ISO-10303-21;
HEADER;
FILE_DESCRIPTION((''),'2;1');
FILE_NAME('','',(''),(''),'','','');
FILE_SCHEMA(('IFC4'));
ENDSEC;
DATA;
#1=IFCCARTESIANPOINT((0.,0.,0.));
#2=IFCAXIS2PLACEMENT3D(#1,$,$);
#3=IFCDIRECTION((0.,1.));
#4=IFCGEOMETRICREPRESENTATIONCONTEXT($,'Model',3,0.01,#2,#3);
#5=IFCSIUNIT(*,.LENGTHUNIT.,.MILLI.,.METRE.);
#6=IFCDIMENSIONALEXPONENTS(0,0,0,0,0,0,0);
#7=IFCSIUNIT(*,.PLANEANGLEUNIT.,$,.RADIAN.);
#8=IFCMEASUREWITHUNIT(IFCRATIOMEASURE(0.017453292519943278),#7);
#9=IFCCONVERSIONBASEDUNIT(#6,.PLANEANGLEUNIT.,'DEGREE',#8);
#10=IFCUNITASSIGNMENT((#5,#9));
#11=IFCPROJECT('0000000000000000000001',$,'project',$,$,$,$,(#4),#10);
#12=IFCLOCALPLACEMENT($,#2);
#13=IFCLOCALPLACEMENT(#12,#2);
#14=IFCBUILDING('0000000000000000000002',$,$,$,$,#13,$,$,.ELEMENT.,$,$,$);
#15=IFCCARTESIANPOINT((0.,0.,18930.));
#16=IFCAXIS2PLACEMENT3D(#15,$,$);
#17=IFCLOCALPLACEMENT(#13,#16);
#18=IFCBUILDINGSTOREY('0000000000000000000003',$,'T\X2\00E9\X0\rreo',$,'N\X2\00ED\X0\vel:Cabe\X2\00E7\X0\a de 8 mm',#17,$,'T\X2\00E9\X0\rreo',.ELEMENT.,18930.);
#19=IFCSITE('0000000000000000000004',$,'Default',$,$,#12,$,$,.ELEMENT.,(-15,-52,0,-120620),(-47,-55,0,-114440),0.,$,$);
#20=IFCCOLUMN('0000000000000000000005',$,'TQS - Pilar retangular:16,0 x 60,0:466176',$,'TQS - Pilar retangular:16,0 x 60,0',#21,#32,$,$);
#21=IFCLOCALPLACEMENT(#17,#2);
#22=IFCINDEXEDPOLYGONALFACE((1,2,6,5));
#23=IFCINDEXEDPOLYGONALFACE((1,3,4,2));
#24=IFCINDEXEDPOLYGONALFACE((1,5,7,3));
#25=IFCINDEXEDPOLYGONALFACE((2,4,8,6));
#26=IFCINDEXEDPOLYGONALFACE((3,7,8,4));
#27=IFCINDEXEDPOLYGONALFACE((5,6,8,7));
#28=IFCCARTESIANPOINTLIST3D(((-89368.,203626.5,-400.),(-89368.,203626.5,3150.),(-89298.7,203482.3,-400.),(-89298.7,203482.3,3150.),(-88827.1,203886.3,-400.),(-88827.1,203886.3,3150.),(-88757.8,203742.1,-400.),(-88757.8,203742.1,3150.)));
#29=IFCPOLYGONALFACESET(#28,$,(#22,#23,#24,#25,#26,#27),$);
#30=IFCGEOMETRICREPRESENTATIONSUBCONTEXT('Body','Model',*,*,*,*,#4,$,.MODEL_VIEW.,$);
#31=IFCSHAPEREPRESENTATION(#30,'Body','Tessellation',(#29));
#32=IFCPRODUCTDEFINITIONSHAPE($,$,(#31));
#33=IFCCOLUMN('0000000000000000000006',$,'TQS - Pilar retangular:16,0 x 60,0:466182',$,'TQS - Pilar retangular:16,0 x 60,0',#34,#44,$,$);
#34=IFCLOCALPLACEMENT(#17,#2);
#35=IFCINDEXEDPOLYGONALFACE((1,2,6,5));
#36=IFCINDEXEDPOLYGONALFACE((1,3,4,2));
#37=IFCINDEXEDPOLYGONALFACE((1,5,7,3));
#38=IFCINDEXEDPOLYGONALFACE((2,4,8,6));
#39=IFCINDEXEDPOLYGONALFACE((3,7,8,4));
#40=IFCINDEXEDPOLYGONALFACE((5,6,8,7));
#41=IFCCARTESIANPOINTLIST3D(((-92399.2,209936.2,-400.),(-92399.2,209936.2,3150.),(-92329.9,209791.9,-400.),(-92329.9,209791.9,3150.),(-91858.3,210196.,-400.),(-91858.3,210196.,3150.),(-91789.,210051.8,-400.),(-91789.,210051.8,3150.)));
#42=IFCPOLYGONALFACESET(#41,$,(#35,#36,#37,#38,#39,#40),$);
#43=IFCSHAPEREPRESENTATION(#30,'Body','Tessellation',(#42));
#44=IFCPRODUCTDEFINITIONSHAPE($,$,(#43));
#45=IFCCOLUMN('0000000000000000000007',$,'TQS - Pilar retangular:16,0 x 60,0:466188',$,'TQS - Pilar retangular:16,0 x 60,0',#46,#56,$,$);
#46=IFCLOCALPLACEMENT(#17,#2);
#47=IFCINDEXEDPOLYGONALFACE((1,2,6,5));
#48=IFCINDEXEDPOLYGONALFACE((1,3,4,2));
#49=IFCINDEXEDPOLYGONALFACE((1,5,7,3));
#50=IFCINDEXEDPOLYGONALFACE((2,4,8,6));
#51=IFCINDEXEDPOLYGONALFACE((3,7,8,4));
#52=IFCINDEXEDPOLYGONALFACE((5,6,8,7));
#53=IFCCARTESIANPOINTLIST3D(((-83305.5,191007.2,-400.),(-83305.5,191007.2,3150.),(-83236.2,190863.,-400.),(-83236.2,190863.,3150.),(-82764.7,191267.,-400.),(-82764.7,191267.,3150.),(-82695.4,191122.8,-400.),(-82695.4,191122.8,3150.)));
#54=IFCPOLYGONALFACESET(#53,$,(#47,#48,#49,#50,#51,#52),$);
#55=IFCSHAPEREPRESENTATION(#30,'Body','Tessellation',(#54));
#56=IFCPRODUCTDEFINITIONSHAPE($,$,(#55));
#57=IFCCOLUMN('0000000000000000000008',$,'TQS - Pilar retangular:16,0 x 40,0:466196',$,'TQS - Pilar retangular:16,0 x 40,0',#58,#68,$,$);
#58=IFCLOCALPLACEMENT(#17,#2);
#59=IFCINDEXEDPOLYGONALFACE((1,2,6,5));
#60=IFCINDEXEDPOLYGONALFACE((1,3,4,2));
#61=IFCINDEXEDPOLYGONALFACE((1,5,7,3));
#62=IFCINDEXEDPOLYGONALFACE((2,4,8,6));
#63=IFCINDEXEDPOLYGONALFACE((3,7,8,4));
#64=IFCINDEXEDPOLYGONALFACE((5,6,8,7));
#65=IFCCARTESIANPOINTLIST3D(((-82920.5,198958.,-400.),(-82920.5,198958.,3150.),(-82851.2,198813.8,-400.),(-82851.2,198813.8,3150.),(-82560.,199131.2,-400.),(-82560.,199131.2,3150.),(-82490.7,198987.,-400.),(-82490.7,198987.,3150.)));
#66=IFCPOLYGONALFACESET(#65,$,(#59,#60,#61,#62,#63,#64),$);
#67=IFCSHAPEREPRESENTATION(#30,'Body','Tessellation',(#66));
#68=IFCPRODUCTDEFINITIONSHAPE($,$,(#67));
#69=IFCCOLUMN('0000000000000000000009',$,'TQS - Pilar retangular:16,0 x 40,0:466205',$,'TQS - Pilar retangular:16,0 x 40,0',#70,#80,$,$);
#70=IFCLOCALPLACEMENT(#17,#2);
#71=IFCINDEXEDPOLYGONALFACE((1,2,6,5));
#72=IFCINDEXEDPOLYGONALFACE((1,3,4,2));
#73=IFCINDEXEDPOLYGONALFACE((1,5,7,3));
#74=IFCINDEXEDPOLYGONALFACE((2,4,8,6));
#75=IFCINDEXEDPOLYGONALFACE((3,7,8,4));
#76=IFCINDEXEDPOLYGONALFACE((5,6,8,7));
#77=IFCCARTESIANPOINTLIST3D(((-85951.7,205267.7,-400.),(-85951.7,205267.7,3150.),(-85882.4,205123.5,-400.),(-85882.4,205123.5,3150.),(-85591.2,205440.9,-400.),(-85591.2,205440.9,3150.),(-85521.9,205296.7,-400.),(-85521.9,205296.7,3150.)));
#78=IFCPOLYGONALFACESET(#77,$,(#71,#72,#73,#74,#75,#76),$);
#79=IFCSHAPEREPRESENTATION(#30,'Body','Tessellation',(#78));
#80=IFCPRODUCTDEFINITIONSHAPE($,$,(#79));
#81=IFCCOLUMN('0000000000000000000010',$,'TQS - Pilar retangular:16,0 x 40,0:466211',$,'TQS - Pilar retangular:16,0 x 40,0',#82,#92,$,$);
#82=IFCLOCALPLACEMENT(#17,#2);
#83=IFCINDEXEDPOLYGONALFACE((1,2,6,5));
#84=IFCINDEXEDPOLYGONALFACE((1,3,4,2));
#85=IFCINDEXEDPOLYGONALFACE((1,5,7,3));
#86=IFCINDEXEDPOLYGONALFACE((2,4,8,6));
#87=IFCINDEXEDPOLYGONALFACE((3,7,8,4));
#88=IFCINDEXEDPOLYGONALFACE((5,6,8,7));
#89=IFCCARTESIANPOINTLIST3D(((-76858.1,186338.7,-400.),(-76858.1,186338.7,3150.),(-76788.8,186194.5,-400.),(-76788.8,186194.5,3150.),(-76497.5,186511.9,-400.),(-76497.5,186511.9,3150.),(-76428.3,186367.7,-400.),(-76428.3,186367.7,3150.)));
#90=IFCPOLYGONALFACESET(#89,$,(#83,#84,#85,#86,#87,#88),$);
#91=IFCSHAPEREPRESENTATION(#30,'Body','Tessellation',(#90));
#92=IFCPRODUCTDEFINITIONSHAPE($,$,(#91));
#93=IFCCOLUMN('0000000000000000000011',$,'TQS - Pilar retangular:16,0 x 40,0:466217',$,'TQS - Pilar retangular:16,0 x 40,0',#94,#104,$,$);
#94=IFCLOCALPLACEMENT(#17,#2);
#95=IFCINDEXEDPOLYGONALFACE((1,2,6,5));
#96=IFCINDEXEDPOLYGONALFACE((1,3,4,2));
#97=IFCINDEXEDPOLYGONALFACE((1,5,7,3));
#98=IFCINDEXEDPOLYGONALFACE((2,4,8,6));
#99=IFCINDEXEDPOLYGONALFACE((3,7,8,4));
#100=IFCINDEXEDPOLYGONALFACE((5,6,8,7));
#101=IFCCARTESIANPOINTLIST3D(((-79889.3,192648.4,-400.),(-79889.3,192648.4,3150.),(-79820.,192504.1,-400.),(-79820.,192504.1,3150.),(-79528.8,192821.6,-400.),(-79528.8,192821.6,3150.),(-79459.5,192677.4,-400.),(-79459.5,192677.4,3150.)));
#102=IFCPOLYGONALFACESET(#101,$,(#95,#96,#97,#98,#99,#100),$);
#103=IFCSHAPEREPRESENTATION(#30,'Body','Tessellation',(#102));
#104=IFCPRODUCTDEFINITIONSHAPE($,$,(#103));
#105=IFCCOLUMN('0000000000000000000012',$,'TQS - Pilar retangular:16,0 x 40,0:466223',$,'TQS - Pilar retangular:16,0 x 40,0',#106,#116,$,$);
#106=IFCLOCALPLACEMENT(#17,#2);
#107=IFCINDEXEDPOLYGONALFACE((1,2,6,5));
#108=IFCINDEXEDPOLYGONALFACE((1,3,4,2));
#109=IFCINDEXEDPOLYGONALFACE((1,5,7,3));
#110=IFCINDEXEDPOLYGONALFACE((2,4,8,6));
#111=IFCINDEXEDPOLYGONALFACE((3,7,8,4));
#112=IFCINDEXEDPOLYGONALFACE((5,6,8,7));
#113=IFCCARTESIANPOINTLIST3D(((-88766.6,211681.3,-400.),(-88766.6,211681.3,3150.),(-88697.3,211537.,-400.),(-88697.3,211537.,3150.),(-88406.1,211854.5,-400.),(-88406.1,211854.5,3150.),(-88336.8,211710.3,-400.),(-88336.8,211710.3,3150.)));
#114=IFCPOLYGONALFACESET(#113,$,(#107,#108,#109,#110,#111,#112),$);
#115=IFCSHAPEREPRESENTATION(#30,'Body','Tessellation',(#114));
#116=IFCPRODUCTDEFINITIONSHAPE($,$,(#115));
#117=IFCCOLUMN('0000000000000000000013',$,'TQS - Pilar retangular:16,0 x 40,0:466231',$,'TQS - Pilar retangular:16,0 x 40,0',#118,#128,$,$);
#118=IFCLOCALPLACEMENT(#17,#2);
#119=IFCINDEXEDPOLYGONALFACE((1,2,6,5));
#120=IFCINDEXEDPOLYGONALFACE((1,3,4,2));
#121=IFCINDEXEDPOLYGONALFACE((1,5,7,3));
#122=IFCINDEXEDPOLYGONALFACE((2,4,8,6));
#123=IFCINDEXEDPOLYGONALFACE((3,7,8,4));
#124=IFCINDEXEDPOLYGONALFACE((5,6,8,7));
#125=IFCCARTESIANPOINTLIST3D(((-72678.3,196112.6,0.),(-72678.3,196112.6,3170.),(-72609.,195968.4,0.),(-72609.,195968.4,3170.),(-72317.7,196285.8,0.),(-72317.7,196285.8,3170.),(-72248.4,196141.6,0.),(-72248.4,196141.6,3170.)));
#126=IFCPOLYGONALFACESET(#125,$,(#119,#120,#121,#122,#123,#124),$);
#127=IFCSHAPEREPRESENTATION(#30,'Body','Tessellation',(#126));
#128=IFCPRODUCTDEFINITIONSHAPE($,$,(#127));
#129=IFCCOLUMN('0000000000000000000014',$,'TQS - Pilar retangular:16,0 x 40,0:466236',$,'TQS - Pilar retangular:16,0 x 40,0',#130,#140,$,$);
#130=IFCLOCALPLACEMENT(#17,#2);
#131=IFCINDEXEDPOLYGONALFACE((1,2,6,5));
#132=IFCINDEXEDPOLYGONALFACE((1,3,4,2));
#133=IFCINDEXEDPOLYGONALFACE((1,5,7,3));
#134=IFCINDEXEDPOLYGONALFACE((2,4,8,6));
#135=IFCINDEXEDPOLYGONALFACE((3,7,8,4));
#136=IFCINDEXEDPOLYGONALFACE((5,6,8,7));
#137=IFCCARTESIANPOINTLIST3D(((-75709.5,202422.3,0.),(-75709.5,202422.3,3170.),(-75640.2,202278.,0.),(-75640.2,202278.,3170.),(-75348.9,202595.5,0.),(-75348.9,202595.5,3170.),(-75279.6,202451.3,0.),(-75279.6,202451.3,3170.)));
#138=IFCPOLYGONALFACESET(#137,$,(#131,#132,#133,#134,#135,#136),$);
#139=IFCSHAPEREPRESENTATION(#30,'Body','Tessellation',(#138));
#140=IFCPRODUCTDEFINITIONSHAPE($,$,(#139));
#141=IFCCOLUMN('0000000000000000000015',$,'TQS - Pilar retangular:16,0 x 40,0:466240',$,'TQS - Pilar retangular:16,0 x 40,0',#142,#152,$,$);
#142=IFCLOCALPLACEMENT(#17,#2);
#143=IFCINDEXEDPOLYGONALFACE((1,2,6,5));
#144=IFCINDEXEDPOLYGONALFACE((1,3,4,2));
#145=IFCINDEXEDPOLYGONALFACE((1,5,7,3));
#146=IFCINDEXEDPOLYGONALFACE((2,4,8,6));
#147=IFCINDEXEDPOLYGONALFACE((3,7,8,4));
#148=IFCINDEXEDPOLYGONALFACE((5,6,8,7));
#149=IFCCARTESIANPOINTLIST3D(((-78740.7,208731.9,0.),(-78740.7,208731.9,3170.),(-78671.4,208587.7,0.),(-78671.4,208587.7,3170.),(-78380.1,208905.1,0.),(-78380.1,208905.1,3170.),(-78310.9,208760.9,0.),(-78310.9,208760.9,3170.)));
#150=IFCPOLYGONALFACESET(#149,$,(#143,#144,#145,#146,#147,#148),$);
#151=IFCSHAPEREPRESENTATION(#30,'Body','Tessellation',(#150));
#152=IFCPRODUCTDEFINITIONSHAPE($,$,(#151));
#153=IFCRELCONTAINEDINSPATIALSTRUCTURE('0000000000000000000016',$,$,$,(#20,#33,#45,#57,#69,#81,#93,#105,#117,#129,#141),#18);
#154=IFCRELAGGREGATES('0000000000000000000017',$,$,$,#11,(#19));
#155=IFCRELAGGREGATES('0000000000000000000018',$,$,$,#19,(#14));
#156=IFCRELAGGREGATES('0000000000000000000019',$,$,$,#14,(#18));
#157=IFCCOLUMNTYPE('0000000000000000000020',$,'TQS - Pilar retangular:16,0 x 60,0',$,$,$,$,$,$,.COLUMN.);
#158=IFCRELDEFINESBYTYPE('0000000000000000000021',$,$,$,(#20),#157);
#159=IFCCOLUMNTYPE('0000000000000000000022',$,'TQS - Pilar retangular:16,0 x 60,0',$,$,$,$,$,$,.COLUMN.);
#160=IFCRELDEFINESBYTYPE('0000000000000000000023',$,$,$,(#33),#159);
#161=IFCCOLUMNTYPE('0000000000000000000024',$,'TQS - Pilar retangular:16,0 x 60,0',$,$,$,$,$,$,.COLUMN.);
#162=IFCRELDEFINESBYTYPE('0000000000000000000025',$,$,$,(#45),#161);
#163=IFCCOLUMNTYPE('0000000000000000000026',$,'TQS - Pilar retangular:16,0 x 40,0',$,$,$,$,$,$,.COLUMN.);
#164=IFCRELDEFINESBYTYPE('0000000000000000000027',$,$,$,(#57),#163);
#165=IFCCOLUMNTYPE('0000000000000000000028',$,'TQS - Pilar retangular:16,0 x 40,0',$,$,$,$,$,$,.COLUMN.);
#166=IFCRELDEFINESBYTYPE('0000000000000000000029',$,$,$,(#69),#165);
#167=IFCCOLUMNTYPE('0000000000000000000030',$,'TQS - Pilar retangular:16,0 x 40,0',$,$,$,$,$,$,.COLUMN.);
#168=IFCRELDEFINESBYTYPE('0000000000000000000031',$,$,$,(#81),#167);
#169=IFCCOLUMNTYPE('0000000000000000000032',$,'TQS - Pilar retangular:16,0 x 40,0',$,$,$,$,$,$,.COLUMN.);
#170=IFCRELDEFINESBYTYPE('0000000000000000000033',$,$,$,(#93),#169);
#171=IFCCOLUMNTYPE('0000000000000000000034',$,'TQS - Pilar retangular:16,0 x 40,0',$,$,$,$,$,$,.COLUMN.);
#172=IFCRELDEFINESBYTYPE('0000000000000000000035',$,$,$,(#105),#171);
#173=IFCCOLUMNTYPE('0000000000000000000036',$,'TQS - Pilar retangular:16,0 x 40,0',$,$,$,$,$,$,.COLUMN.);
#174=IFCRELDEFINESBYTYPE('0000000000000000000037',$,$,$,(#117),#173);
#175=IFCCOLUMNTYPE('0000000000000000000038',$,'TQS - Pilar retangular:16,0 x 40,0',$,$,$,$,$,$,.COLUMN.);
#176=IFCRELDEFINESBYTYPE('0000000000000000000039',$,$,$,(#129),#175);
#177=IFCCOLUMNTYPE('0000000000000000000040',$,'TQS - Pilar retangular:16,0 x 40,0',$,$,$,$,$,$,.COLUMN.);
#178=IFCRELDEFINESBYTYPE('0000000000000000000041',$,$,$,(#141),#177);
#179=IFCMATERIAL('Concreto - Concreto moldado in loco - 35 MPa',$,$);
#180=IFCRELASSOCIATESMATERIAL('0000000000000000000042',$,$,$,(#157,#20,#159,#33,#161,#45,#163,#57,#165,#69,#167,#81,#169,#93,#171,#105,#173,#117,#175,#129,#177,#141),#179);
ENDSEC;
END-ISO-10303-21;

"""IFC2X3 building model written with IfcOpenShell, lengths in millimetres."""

from ifc_helpers import new_model, entity, si_unit, converted_unit, direction, frame, origin, origin_2d_with_axis, place, context, subcontext, project, spatial, rectangle, extrude, source, transform, mapped, material, type_object, type_shapes, element, save


model = new_model("IFC2X3")

# Units and contexts
model_context = context("Model", 3, precision=0.01, world=origin(), true_north=direction((0.0, 1.0)))
body_context = subcontext(model_context, "Body", "Model", "MODEL_VIEW")
ifc_project = project(units=[si_unit("LENGTHUNIT", "METRE", prefix="MILLI"), converted_unit("PLANEANGLEUNIT", "DEGREE", entity("IfcRatioMeasure", 0.017453292519943278), si_unit("PLANEANGLEUNIT", "RADIAN"), dimensions=[0, 0, 0, 0, 0, 0, 0])], contexts=[model_context])

# Site, building, storey
site_placement = place(None, origin())
site = spatial("IfcSite", under=ifc_project, at=site_placement, Name="Default", CompositionType="ELEMENT", RefLatitude=(-15, -52, 0, -120620), RefLongitude=(-47, -55, 0, -114440), RefElevation=0.0)
building_placement = place(site_placement, origin())
building = spatial("IfcBuilding", under=site, at=building_placement, CompositionType="ELEMENT")
storey_placement = place(building_placement, frame((0.0, 0.0, 18930.0)))
storey = spatial("IfcBuildingStorey", under=building, at=storey_placement, Name="Térreo", ObjectType="Nível:Cabeça de 8 mm", LongName="Térreo", CompositionType="ELEMENT", Elevation=18930.0)

# Columns
ifc_material = material(Name="Concreto - Concreto moldado in loco - 35 MPa")
column_type_1 = type_object("IfcColumnType", Name="TQS - Pilar retangular:16,0 x 60,0", PredefinedType="COLUMN", material=ifc_material)
shared_shape_1 = source(origin(), body_context, "Body", "SweptSolid", [
    extrude(rectangle(XDim=600.0, YDim=160.0, at=origin_2d_with_axis()), frame((-89062.9, 203684.3, 18530.0), z_axis=(0.0, 0.0, 1.0), x_axis=(-0.90138, -0.43303, 0.0)), (0.0, 0.0, 1.0), 3550.0),
])
type_shapes(column_type_1, [shared_shape_1])
column_1_placement = place(storey_placement, frame((0.0, 0.0, -18930.0)))
element("IfcColumn", 1, at=column_1_placement, inside=storey, type_object=column_type_1, material=ifc_material, Name="TQS - Pilar retangular:16,0 x 60,0:466176", ObjectType="TQS - Pilar retangular:16,0 x 60,0", context=body_context, shape_type="MappedRepresentation", body=[
    mapped(shared_shape_1, transform((0.0, 0.0, 0.0), scale=1.0)),
])
column_type_2 = type_object("IfcColumnType", Name="TQS - Pilar retangular:16,0 x 60,0", PredefinedType="COLUMN", material=ifc_material)
shared_shape_2 = source(origin(), body_context, "Body", "SweptSolid", [
    extrude(rectangle(XDim=600.0, YDim=160.0, at=origin_2d_with_axis()), frame((-92094.1, 209994.0, 18530.0), z_axis=(0.0, 0.0, 1.0), x_axis=(-0.90138, -0.43303, 0.0)), (0.0, 0.0, 1.0), 3550.0),
])
type_shapes(column_type_2, [shared_shape_2])
column_2_placement = place(storey_placement, frame((0.0, 0.0, -18930.0)))
element("IfcColumn", 2, at=column_2_placement, inside=storey, type_object=column_type_2, material=ifc_material, Name="TQS - Pilar retangular:16,0 x 60,0:466182", ObjectType="TQS - Pilar retangular:16,0 x 60,0", context=body_context, shape_type="MappedRepresentation", body=[
    mapped(shared_shape_2, transform((0.0, 0.0, 0.0), scale=1.0)),
])
column_type_3 = type_object("IfcColumnType", Name="TQS - Pilar retangular:16,0 x 60,0", PredefinedType="COLUMN", material=ifc_material)
shared_shape_3 = source(origin(), body_context, "Body", "SweptSolid", [
    extrude(rectangle(XDim=600.0, YDim=160.0, at=origin_2d_with_axis()), frame((-83000.5, 191065.0, 18530.0), z_axis=(0.0, 0.0, 1.0), x_axis=(-0.90138, -0.43303, 0.0)), (0.0, 0.0, 1.0), 3550.0),
])
type_shapes(column_type_3, [shared_shape_3])
column_3_placement = place(storey_placement, frame((0.0, 0.0, -18930.0)))
element("IfcColumn", 3, at=column_3_placement, inside=storey, type_object=column_type_3, material=ifc_material, Name="TQS - Pilar retangular:16,0 x 60,0:466188", ObjectType="TQS - Pilar retangular:16,0 x 60,0", context=body_context, shape_type="MappedRepresentation", body=[
    mapped(shared_shape_3, transform((0.0, 0.0, 0.0), scale=1.0)),
])
column_type_4 = type_object("IfcColumnType", Name="TQS - Pilar retangular:16,0 x 40,0", PredefinedType="COLUMN", material=ifc_material)
shared_shape_4 = source(origin(), body_context, "Body", "SweptSolid", [
    extrude(rectangle(XDim=400.0, YDim=160.0, at=origin_2d_with_axis()), frame((-82705.6, 198972.5, 18530.0), z_axis=(0.0, 0.0, 1.0), x_axis=(-0.90138, -0.43303, 0.0)), (0.0, 0.0, 1.0), 3550.0),
])
type_shapes(column_type_4, [shared_shape_4])
column_4_placement = place(storey_placement, frame((0.0, 0.0, -18930.0)))
element("IfcColumn", 4, at=column_4_placement, inside=storey, type_object=column_type_4, material=ifc_material, Name="TQS - Pilar retangular:16,0 x 40,0:466196", ObjectType="TQS - Pilar retangular:16,0 x 40,0", context=body_context, shape_type="MappedRepresentation", body=[
    mapped(shared_shape_4, transform((0.0, 0.0, 0.0), scale=1.0)),
])
column_type_5 = type_object("IfcColumnType", Name="TQS - Pilar retangular:16,0 x 40,0", PredefinedType="COLUMN", material=ifc_material)
shared_shape_5 = source(origin(), body_context, "Body", "SweptSolid", [
    extrude(rectangle(XDim=400.0, YDim=160.0, at=origin_2d_with_axis()), frame((-85736.8, 205282.2, 18530.0), z_axis=(0.0, 0.0, 1.0), x_axis=(-0.90138, -0.43303, 0.0)), (0.0, 0.0, 1.0), 3550.0),
])
type_shapes(column_type_5, [shared_shape_5])
column_5_placement = place(storey_placement, frame((0.0, 0.0, -18930.0)))
element("IfcColumn", 5, at=column_5_placement, inside=storey, type_object=column_type_5, material=ifc_material, Name="TQS - Pilar retangular:16,0 x 40,0:466205", ObjectType="TQS - Pilar retangular:16,0 x 40,0", context=body_context, shape_type="MappedRepresentation", body=[
    mapped(shared_shape_5, transform((0.0, 0.0, 0.0), scale=1.0)),
])
column_type_6 = type_object("IfcColumnType", Name="TQS - Pilar retangular:16,0 x 40,0", PredefinedType="COLUMN", material=ifc_material)
shared_shape_6 = source(origin(), body_context, "Body", "SweptSolid", [
    extrude(rectangle(XDim=400.0, YDim=160.0, at=origin_2d_with_axis()), frame((-76643.2, 186353.2, 18530.0), z_axis=(0.0, 0.0, 1.0), x_axis=(-0.90138, -0.43303, 0.0)), (0.0, 0.0, 1.0), 3550.0),
])
type_shapes(column_type_6, [shared_shape_6])
column_6_placement = place(storey_placement, frame((0.0, 0.0, -18930.0)))
element("IfcColumn", 6, at=column_6_placement, inside=storey, type_object=column_type_6, material=ifc_material, Name="TQS - Pilar retangular:16,0 x 40,0:466211", ObjectType="TQS - Pilar retangular:16,0 x 40,0", context=body_context, shape_type="MappedRepresentation", body=[
    mapped(shared_shape_6, transform((0.0, 0.0, 0.0), scale=1.0)),
])
column_type_7 = type_object("IfcColumnType", Name="TQS - Pilar retangular:16,0 x 40,0", PredefinedType="COLUMN", material=ifc_material)
shared_shape_7 = source(origin(), body_context, "Body", "SweptSolid", [
    extrude(rectangle(XDim=400.0, YDim=160.0, at=origin_2d_with_axis()), frame((-79674.4, 192662.9, 18530.0), z_axis=(0.0, 0.0, 1.0), x_axis=(-0.90138, -0.43303, 0.0)), (0.0, 0.0, 1.0), 3550.0),
])
type_shapes(column_type_7, [shared_shape_7])
column_7_placement = place(storey_placement, frame((0.0, 0.0, -18930.0)))
element("IfcColumn", 7, at=column_7_placement, inside=storey, type_object=column_type_7, material=ifc_material, Name="TQS - Pilar retangular:16,0 x 40,0:466217", ObjectType="TQS - Pilar retangular:16,0 x 40,0", context=body_context, shape_type="MappedRepresentation", body=[
    mapped(shared_shape_7, transform((0.0, 0.0, 0.0), scale=1.0)),
])
column_type_8 = type_object("IfcColumnType", Name="TQS - Pilar retangular:16,0 x 40,0", PredefinedType="COLUMN", material=ifc_material)
shared_shape_8 = source(origin(), body_context, "Body", "SweptSolid", [
    extrude(rectangle(XDim=400.0, YDim=160.0, at=origin_2d_with_axis()), frame((-88551.7, 211695.8, 18530.0), z_axis=(0.0, 0.0, 1.0), x_axis=(-0.90138, -0.43303, 0.0)), (0.0, 0.0, 1.0), 3550.0),
])
type_shapes(column_type_8, [shared_shape_8])
column_8_placement = place(storey_placement, frame((0.0, 0.0, -18930.0)))
element("IfcColumn", 8, at=column_8_placement, inside=storey, type_object=column_type_8, material=ifc_material, Name="TQS - Pilar retangular:16,0 x 40,0:466223", ObjectType="TQS - Pilar retangular:16,0 x 40,0", context=body_context, shape_type="MappedRepresentation", body=[
    mapped(shared_shape_8, transform((0.0, 0.0, 0.0), scale=1.0)),
])
column_type_9 = type_object("IfcColumnType", Name="TQS - Pilar retangular:16,0 x 40,0", PredefinedType="COLUMN", material=ifc_material)
shared_shape_9 = source(origin(), body_context, "Body", "SweptSolid", [
    extrude(rectangle(XDim=400.0, YDim=160.0, at=origin_2d_with_axis()), frame((-72463.4, 196127.1, 18930.0), z_axis=(0.0, 0.0, 1.0), x_axis=(-0.90138, -0.43303, 0.0)), (0.0, 0.0, 1.0), 3170.0),
])
type_shapes(column_type_9, [shared_shape_9])
column_9_placement = place(storey_placement, frame((0.0, 0.0, -18930.0)))
element("IfcColumn", 9, at=column_9_placement, inside=storey, type_object=column_type_9, material=ifc_material, Name="TQS - Pilar retangular:16,0 x 40,0:466231", ObjectType="TQS - Pilar retangular:16,0 x 40,0", context=body_context, shape_type="MappedRepresentation", body=[
    mapped(shared_shape_9, transform((0.0, 0.0, 0.0), scale=1.0)),
])
column_type_10 = type_object("IfcColumnType", Name="TQS - Pilar retangular:16,0 x 40,0", PredefinedType="COLUMN", material=ifc_material)
shared_shape_10 = source(origin(), body_context, "Body", "SweptSolid", [
    extrude(rectangle(XDim=400.0, YDim=160.0, at=origin_2d_with_axis()), frame((-75494.6, 202436.8, 18930.0), z_axis=(0.0, 0.0, 1.0), x_axis=(-0.90138, -0.43303, 0.0)), (0.0, 0.0, 1.0), 3170.0),
])
type_shapes(column_type_10, [shared_shape_10])
column_10_placement = place(storey_placement, frame((0.0, 0.0, -18930.0)))
element("IfcColumn", 10, at=column_10_placement, inside=storey, type_object=column_type_10, material=ifc_material, Name="TQS - Pilar retangular:16,0 x 40,0:466236", ObjectType="TQS - Pilar retangular:16,0 x 40,0", context=body_context, shape_type="MappedRepresentation", body=[
    mapped(shared_shape_10, transform((0.0, 0.0, 0.0), scale=1.0)),
])
column_type_11 = type_object("IfcColumnType", Name="TQS - Pilar retangular:16,0 x 40,0", PredefinedType="COLUMN", material=ifc_material)
shared_shape_11 = source(origin(), body_context, "Body", "SweptSolid", [
    extrude(rectangle(XDim=400.0, YDim=160.0, at=origin_2d_with_axis()), frame((-78525.8, 208746.4, 18930.0), z_axis=(0.0, 0.0, 1.0), x_axis=(-0.90138, -0.43303, 0.0)), (0.0, 0.0, 1.0), 3170.0),
])
type_shapes(column_type_11, [shared_shape_11])
column_11_placement = place(storey_placement, frame((0.0, 0.0, -18930.0)))
element("IfcColumn", 11, at=column_11_placement, inside=storey, type_object=column_type_11, material=ifc_material, Name="TQS - Pilar retangular:16,0 x 40,0:466240", ObjectType="TQS - Pilar retangular:16,0 x 40,0", context=body_context, shape_type="MappedRepresentation", body=[
    mapped(shared_shape_11, transform((0.0, 0.0, 0.0), scale=1.0)),
])

save(model, "model.ifc")
